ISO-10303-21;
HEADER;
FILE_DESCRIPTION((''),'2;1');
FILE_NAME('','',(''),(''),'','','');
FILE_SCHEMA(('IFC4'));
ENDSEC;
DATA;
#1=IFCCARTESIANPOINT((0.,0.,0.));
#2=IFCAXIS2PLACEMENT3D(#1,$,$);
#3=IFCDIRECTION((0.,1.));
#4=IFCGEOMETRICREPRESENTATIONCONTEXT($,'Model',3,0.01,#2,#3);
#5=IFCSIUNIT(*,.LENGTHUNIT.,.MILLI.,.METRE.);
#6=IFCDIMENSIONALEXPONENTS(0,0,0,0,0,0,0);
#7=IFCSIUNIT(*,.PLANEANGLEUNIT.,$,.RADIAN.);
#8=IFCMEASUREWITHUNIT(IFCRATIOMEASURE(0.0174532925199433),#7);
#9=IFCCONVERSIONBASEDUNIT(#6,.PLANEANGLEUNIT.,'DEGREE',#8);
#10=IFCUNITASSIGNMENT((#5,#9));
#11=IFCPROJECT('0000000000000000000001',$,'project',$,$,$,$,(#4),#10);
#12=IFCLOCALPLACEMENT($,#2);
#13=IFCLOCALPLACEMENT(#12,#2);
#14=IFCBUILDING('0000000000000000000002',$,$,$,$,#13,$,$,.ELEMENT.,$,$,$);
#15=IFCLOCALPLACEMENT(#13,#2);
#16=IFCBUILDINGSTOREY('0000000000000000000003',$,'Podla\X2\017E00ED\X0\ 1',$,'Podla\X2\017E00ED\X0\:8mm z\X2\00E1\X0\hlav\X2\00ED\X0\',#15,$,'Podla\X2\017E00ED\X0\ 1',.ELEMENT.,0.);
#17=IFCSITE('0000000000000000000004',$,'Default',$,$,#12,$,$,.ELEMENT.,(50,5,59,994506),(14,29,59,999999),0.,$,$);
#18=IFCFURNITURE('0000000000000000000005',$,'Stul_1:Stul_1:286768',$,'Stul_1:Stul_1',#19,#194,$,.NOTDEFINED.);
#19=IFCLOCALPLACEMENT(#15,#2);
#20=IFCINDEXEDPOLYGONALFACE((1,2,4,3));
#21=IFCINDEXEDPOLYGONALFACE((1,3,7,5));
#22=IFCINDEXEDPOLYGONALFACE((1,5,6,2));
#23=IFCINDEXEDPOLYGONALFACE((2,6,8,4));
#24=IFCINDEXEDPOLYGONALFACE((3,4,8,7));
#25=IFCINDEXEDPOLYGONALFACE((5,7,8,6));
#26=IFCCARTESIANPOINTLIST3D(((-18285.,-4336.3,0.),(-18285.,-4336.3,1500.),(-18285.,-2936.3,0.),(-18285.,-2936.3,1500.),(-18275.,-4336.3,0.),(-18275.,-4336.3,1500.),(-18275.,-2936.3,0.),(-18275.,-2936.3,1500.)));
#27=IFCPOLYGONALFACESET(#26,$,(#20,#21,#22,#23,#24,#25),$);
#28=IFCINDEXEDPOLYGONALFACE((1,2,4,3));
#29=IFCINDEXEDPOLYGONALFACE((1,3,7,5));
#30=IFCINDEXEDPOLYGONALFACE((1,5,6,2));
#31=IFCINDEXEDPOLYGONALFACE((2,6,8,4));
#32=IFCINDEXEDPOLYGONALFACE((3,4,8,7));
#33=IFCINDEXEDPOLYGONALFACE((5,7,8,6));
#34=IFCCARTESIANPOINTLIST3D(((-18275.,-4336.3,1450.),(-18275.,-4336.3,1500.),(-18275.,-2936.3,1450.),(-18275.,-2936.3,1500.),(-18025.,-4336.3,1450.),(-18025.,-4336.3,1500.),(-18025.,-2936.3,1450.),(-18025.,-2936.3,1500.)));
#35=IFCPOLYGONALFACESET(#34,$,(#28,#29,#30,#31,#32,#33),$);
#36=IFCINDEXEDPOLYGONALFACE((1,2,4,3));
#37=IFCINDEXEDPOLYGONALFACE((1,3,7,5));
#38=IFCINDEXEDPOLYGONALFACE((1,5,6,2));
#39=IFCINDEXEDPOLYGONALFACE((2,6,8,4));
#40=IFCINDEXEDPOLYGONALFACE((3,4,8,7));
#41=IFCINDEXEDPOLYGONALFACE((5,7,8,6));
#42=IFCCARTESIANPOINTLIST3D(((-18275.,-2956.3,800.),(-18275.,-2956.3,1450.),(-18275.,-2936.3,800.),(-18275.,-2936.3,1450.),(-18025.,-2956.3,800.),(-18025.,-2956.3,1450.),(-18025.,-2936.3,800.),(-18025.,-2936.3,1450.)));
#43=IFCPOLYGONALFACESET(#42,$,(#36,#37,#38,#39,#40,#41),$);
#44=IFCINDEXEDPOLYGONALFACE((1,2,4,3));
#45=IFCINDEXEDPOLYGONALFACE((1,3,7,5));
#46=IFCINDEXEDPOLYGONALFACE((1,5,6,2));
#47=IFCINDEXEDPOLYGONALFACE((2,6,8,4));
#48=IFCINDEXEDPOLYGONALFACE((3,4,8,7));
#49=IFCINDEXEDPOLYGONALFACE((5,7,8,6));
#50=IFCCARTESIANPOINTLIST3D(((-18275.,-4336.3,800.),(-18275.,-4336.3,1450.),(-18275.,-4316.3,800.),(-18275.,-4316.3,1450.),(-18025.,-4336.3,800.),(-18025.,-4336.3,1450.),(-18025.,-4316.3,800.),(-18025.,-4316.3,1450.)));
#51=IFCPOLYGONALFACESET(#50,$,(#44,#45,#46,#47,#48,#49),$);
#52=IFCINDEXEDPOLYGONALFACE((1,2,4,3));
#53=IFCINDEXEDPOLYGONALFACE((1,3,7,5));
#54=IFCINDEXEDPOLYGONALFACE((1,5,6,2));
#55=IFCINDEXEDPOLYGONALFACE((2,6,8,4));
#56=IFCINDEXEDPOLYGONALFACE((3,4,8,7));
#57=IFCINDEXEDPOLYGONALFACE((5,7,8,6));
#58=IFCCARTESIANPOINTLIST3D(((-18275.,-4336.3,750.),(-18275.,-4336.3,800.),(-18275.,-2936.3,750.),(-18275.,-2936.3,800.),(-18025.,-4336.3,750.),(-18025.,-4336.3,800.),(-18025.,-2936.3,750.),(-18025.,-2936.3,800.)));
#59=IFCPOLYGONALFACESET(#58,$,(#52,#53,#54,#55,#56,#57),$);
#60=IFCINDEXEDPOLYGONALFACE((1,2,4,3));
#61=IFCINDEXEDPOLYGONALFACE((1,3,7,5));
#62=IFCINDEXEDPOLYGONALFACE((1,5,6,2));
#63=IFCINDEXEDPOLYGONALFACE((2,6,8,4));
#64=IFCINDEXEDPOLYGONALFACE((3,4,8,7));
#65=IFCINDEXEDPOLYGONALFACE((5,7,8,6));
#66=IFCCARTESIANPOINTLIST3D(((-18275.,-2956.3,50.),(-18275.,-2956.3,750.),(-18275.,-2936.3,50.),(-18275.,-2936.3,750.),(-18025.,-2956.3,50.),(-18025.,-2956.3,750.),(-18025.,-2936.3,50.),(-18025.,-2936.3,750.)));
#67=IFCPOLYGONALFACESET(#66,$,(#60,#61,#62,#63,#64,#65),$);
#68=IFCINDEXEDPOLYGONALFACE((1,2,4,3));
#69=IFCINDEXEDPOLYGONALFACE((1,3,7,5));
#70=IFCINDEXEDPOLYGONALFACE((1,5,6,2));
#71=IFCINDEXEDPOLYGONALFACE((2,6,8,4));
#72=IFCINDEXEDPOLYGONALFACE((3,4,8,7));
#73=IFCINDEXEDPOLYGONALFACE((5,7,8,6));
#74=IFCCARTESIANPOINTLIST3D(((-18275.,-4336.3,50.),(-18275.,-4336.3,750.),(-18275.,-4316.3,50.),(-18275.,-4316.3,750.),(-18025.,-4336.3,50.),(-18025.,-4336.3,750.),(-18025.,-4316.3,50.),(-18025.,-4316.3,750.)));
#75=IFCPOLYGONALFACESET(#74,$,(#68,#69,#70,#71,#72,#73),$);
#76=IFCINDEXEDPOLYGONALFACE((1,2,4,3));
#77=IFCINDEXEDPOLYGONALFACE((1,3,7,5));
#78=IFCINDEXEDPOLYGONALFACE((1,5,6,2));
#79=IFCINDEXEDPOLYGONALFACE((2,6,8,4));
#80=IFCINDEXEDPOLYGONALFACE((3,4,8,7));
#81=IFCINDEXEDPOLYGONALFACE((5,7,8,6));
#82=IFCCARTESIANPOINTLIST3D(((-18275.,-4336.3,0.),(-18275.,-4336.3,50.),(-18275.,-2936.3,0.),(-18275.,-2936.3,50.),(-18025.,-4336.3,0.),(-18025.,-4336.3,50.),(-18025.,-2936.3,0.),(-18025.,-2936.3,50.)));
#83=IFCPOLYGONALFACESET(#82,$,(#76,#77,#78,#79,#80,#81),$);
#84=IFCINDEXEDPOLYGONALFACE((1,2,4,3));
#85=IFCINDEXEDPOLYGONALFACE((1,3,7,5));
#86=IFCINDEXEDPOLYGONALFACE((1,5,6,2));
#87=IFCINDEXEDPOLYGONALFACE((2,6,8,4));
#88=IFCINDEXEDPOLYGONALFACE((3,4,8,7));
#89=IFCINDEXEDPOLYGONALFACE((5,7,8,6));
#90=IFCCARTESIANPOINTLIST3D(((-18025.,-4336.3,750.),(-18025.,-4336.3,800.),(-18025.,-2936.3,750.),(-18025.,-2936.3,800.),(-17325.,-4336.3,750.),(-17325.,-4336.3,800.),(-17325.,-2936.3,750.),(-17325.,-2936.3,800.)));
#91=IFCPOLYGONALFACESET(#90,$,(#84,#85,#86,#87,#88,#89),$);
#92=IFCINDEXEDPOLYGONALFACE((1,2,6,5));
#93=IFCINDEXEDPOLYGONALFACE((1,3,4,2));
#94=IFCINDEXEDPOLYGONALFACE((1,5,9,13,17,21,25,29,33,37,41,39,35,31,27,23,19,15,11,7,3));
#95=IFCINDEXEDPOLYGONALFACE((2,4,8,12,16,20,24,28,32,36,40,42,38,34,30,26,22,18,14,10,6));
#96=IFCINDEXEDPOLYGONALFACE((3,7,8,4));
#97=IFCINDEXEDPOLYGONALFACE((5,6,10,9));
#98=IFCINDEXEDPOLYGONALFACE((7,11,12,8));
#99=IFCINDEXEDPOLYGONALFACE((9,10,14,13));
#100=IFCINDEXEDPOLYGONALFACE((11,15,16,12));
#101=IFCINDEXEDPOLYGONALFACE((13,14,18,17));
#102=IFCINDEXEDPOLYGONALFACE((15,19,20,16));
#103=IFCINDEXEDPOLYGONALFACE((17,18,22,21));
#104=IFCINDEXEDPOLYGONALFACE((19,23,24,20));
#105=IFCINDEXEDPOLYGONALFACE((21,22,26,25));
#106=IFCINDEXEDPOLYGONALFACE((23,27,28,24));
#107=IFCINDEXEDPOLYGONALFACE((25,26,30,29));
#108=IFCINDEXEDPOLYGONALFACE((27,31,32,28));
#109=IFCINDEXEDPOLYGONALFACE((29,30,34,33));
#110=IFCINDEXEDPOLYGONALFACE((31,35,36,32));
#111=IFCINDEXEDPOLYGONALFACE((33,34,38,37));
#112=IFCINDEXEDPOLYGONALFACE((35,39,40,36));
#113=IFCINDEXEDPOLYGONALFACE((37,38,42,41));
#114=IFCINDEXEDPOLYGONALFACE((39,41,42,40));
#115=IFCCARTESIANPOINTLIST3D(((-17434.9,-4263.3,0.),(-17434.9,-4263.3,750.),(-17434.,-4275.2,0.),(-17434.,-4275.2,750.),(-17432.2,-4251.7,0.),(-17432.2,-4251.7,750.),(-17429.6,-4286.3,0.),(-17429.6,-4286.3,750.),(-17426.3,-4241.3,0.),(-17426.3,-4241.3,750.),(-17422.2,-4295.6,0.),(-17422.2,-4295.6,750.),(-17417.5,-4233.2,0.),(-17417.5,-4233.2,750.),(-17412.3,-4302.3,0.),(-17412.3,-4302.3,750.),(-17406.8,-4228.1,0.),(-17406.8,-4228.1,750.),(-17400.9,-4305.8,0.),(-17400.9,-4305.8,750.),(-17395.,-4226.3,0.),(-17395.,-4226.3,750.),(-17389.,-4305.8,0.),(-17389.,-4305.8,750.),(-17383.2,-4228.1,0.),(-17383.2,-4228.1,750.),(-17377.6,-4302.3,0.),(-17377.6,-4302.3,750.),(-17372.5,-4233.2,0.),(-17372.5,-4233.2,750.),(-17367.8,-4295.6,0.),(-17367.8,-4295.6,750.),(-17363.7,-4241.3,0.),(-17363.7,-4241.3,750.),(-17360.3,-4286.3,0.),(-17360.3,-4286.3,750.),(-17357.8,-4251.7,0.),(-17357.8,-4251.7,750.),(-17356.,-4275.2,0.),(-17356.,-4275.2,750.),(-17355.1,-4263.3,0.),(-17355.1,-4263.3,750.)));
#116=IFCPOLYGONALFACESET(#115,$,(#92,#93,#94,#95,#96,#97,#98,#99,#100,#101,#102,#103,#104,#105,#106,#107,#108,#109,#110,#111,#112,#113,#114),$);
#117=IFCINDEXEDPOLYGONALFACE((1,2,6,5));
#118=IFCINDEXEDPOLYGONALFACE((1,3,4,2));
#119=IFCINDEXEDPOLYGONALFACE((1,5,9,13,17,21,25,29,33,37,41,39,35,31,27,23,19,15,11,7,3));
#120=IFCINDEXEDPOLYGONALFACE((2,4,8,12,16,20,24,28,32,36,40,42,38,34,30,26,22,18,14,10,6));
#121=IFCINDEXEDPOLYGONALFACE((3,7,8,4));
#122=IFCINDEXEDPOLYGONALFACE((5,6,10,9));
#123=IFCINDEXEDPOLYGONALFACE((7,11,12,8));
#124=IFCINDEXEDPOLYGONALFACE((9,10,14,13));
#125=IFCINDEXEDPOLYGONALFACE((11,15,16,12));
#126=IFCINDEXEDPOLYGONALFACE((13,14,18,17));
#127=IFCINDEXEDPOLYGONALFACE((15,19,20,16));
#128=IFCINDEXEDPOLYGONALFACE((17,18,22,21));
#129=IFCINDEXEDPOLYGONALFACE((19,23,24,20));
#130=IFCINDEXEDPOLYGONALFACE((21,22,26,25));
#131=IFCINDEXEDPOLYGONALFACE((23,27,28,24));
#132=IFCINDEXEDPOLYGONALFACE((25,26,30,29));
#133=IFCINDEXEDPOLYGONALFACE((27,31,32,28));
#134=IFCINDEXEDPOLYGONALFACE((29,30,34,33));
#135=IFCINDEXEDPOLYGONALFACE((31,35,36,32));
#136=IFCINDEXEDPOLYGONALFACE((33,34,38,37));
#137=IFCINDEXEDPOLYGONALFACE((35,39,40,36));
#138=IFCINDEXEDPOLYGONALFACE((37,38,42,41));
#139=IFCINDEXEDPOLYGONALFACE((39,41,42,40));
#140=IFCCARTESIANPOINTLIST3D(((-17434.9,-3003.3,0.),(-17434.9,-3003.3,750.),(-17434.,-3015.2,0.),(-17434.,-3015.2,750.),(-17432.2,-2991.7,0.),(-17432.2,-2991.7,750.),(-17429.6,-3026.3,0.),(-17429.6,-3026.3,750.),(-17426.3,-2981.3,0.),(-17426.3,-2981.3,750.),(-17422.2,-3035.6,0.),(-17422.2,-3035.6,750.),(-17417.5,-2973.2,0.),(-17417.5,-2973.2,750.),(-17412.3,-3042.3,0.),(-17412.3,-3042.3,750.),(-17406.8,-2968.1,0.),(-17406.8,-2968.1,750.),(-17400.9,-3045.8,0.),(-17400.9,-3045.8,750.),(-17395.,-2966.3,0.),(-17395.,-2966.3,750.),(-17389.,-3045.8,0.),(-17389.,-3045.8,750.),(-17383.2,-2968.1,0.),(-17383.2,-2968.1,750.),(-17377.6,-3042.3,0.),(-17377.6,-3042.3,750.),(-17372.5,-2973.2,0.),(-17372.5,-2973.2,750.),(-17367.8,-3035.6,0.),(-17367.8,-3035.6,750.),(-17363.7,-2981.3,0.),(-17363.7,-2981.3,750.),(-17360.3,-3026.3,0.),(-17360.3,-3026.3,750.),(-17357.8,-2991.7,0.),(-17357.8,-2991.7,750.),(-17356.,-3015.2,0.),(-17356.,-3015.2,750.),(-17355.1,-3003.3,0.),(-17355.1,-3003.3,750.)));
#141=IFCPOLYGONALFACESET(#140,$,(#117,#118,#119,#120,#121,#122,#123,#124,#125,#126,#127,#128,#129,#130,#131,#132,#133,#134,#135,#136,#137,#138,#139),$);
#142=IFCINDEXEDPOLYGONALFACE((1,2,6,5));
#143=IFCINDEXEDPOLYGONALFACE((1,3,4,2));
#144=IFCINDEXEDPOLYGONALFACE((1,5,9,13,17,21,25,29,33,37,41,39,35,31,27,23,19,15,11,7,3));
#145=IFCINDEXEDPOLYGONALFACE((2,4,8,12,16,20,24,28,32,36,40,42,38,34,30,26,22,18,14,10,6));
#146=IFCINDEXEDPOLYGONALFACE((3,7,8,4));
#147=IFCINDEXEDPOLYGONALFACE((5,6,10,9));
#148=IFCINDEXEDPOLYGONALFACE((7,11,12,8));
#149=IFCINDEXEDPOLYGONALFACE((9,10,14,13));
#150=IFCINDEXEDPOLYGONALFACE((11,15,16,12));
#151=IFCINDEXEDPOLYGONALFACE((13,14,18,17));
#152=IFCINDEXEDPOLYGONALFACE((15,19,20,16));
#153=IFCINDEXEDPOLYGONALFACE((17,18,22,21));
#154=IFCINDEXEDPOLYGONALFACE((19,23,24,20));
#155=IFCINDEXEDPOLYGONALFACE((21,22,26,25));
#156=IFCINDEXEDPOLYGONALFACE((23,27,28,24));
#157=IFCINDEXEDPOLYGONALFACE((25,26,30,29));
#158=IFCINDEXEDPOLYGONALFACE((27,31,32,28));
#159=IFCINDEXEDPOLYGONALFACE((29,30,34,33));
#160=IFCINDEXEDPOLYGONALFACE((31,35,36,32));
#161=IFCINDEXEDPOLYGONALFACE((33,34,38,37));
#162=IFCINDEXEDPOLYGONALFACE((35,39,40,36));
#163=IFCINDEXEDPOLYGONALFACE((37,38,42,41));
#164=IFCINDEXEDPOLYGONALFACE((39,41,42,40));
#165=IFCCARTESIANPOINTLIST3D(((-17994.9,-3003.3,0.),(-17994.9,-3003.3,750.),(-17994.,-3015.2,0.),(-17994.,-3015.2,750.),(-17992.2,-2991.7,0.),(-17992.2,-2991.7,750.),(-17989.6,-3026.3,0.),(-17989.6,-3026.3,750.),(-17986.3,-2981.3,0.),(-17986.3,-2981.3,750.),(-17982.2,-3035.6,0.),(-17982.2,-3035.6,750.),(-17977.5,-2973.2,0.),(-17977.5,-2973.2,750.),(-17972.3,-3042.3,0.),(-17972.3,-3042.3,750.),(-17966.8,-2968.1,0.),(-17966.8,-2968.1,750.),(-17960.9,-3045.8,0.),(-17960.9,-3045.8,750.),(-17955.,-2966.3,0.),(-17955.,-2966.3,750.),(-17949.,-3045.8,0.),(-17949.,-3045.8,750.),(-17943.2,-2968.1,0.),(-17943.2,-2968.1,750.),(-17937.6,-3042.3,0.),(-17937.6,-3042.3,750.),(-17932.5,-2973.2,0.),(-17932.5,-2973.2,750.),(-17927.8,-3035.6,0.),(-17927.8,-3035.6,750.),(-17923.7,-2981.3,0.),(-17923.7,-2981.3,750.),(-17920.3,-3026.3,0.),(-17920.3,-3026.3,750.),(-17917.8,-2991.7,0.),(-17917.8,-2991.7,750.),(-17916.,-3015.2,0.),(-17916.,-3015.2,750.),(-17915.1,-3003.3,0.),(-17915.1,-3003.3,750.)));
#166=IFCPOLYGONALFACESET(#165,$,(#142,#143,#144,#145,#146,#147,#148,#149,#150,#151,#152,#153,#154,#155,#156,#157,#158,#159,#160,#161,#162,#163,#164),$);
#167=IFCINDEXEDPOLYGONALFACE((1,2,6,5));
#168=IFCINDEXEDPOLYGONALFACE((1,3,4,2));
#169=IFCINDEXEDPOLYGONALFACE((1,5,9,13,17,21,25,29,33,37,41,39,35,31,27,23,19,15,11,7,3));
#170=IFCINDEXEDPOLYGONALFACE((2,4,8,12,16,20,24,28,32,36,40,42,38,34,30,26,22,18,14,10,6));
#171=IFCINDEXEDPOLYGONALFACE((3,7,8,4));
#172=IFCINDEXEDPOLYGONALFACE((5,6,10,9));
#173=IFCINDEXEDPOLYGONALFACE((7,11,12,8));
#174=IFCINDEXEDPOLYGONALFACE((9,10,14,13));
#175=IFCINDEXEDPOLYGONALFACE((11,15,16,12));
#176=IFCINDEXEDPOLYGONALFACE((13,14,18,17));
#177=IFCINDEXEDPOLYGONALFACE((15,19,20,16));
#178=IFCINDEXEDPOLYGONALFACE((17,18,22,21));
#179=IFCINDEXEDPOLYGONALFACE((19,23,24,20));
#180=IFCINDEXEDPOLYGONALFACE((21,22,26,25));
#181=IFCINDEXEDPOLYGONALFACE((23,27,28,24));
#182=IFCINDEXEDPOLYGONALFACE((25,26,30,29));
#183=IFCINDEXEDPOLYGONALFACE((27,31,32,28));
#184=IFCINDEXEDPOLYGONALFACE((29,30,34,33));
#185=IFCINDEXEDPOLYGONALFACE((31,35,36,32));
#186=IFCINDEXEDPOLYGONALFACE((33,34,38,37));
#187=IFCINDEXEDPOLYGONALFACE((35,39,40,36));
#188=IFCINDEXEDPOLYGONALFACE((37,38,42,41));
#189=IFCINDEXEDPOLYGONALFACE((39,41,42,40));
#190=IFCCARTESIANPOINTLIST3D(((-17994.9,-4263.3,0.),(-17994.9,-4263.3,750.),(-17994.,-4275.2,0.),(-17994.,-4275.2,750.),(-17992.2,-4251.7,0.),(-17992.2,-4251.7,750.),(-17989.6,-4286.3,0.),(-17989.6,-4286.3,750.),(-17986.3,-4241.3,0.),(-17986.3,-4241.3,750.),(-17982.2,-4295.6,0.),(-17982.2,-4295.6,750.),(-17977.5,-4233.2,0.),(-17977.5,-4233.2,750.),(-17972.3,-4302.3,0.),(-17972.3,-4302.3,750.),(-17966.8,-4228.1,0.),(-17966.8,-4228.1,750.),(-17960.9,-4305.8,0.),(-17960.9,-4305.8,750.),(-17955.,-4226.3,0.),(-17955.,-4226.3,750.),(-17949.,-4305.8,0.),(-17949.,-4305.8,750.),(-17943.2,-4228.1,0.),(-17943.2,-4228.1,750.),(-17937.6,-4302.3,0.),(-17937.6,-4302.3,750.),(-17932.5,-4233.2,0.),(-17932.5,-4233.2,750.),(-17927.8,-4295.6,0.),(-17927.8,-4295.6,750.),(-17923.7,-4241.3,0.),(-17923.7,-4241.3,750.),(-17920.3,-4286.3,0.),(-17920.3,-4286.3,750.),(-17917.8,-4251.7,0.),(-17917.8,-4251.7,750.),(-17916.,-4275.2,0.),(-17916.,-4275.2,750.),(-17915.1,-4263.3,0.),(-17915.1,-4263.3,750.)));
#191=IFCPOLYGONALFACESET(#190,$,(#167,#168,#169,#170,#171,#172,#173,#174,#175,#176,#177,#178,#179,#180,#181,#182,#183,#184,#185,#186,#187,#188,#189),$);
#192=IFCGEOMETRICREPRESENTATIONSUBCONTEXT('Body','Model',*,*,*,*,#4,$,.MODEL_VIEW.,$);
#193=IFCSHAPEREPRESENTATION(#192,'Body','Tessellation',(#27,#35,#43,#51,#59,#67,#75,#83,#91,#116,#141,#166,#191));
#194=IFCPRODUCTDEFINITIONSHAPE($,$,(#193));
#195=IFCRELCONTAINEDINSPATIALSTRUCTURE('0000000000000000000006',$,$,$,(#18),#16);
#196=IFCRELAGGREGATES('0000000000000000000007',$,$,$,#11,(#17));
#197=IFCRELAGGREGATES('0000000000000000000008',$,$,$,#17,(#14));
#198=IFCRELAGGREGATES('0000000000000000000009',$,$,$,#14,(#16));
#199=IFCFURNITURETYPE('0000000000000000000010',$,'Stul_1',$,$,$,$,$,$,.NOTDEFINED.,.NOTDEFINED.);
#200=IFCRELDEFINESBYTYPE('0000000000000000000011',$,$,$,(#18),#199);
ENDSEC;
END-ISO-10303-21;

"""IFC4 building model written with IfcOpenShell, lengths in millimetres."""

from ifc_helpers import new_model, entity, si_unit, converted_unit, direction, frame, frame_2d, origin, origin_2d_with_axis, place, context, subcontext, project, spatial, rectangle, circle, extrude, source, transform, mapped, type_object, type_shapes, element, save


model = new_model("IFC4")

# Units and contexts
model_context = context("Model", 3, precision=0.01, world=origin(), true_north=direction((0.0, 1.0)))
body_context = subcontext(model_context, "Body", "Model", "MODEL_VIEW")
ifc_project = project(units=[si_unit("LENGTHUNIT", "METRE", prefix="MILLI"), converted_unit("PLANEANGLEUNIT", "DEGREE", entity("IfcRatioMeasure", 0.0174532925199433), si_unit("PLANEANGLEUNIT", "RADIAN"), dimensions=[0, 0, 0, 0, 0, 0, 0])], contexts=[model_context])

# Site, building, storey
site_placement = place(None, origin())
site = spatial("IfcSite", under=ifc_project, at=site_placement, Name="Default", CompositionType="ELEMENT", RefLatitude=(50, 5, 59, 994506), RefLongitude=(14, 29, 59, 999999), RefElevation=0.0)
building_placement = place(site_placement, origin())
building = spatial("IfcBuilding", under=site, at=building_placement, CompositionType="ELEMENT")
storey_placement = place(building_placement, origin())
storey = spatial("IfcBuildingStorey", under=building, at=storey_placement, Name="Podlaží 1", ObjectType="Podlaží:8mm záhlaví", LongName="Podlaží 1", CompositionType="ELEMENT", Elevation=0.0)

# Furniture
furniture_type = type_object("IfcFurnitureType", Name="Stul_1", AssemblyPlace="NOTDEFINED", PredefinedType="NOTDEFINED")
shared_shape_1 = source(origin(), body_context, "Body", "SweptSolid", [
    extrude(rectangle(XDim=1400.0, YDim=10.0, at=origin_2d_with_axis()), frame((0.0, 605.0, 0.0), z_axis=(0.0, 0.0, 1.0), x_axis=(-1.0, 0.0, 0.0)), (0.0, 0.0, 1.0), 1500.0),
    extrude(rectangle(XDim=1400.0, YDim=250.0, at=frame_2d((0.0, 0.0), x_axis=(1.0, 0.0))), frame((0.0, 475.0, 1450.0), z_axis=(0.0, 0.0, 1.0), x_axis=(-1.0, 0.0, 0.0)), (0.0, 0.0, 1.0), 50.0),
    extrude(rectangle(XDim=20.0, YDim=250.0, at=origin_2d_with_axis()), frame((690.0, 475.0, 800.0), z_axis=(0.0, 0.0, 1.0), x_axis=(-1.0, 0.0, 0.0)), (0.0, 0.0, 1.0), 650.0),
    extrude(rectangle(XDim=20.0, YDim=250.0, at=frame_2d((0.0, 0.0), x_axis=(1.0, 0.0))), frame((-690.0, 475.0, 800.0), z_axis=(0.0, 0.0, 1.0), x_axis=(-1.0, 0.0, 0.0)), (0.0, 0.0, 1.0), 650.0),
    extrude(rectangle(XDim=1400.0, YDim=250.0, at=origin_2d_with_axis()), frame((0.0, 475.0, 750.0), z_axis=(0.0, 0.0, 1.0), x_axis=(-1.0, 0.0, 0.0)), (0.0, 0.0, 1.0), 50.0),
    extrude(rectangle(XDim=20.0, YDim=250.0, at=origin_2d_with_axis()), frame((690.0, 475.0, 50.0), z_axis=(0.0, 0.0, 1.0), x_axis=(-1.0, 0.0, 0.0)), (0.0, 0.0, 1.0), 700.0),
    extrude(rectangle(XDim=20.0, YDim=250.0, at=frame_2d((0.0, 0.0), x_axis=(1.0, 0.0))), frame((-690.0, 475.0, 50.0), z_axis=(0.0, 0.0, 1.0), x_axis=(-1.0, 0.0, 0.0)), (0.0, 0.0, 1.0), 700.0),
    extrude(rectangle(XDim=1400.0, YDim=250.0, at=origin_2d_with_axis()), frame((0.0, 475.0, 0.0), z_axis=(0.0, 0.0, 1.0), x_axis=(-1.0, 0.0, 0.0)), (0.0, 0.0, 1.0), 50.0),
    extrude(rectangle(XDim=1400.0, YDim=700.0, at=origin_2d_with_axis()), frame((0.0, 0.0, 750.0), z_axis=(0.0, 0.0, 1.0), x_axis=(-1.0, 0.0, 0.0)), (0.0, 0.0, 1.0), 50.0),
    extrude(circle(Radius=40.0, at=frame_2d((0.0, 0.0), x_axis=(1.0, 0.0))), frame((-630.0, -280.0, 0.0)), (0.0, 0.0, 1.0), 750.0),
    extrude(circle(Radius=40.0, at=frame_2d((0.0, 0.0), x_axis=(1.0, 0.0))), frame((630.0, -280.0, 0.0)), (0.0, 0.0, 1.0), 750.0),
    extrude(circle(Radius=40.0, at=frame_2d((0.0, 0.0), x_axis=(1.0, 0.0))), frame((630.0, 280.0, 0.0)), (0.0, 0.0, 1.0), 750.0),
    extrude(circle(Radius=40.0, at=frame_2d((0.0, 0.0), x_axis=(1.0, 0.0))), frame((-630.0, 280.0, 0.0)), (0.0, 0.0, 1.0), 750.0),
])
type_shapes(furniture_type, [shared_shape_1])
for number, where, z_axis, x_axis, name in (
    (1, (-17675.0, -3636.3, 0.0), (0.0, 0.0, 1.0), (0.0, 1.0, 0.0), "Stul_1:Stul_1:286768"),
):
    element("IfcFurniture", number, at=place(storey_placement, frame(where, z_axis=z_axis, x_axis=x_axis)), inside=storey, type_object=furniture_type, Name=name, ObjectType="Stul_1:Stul_1", PredefinedType="NOTDEFINED", context=body_context, shape_type="MappedRepresentation", body=[
        mapped(shared_shape_1, transform((0.0, 0.0, 0.0), scale=1.0)),
    ])

save(model, "model.ifc")
